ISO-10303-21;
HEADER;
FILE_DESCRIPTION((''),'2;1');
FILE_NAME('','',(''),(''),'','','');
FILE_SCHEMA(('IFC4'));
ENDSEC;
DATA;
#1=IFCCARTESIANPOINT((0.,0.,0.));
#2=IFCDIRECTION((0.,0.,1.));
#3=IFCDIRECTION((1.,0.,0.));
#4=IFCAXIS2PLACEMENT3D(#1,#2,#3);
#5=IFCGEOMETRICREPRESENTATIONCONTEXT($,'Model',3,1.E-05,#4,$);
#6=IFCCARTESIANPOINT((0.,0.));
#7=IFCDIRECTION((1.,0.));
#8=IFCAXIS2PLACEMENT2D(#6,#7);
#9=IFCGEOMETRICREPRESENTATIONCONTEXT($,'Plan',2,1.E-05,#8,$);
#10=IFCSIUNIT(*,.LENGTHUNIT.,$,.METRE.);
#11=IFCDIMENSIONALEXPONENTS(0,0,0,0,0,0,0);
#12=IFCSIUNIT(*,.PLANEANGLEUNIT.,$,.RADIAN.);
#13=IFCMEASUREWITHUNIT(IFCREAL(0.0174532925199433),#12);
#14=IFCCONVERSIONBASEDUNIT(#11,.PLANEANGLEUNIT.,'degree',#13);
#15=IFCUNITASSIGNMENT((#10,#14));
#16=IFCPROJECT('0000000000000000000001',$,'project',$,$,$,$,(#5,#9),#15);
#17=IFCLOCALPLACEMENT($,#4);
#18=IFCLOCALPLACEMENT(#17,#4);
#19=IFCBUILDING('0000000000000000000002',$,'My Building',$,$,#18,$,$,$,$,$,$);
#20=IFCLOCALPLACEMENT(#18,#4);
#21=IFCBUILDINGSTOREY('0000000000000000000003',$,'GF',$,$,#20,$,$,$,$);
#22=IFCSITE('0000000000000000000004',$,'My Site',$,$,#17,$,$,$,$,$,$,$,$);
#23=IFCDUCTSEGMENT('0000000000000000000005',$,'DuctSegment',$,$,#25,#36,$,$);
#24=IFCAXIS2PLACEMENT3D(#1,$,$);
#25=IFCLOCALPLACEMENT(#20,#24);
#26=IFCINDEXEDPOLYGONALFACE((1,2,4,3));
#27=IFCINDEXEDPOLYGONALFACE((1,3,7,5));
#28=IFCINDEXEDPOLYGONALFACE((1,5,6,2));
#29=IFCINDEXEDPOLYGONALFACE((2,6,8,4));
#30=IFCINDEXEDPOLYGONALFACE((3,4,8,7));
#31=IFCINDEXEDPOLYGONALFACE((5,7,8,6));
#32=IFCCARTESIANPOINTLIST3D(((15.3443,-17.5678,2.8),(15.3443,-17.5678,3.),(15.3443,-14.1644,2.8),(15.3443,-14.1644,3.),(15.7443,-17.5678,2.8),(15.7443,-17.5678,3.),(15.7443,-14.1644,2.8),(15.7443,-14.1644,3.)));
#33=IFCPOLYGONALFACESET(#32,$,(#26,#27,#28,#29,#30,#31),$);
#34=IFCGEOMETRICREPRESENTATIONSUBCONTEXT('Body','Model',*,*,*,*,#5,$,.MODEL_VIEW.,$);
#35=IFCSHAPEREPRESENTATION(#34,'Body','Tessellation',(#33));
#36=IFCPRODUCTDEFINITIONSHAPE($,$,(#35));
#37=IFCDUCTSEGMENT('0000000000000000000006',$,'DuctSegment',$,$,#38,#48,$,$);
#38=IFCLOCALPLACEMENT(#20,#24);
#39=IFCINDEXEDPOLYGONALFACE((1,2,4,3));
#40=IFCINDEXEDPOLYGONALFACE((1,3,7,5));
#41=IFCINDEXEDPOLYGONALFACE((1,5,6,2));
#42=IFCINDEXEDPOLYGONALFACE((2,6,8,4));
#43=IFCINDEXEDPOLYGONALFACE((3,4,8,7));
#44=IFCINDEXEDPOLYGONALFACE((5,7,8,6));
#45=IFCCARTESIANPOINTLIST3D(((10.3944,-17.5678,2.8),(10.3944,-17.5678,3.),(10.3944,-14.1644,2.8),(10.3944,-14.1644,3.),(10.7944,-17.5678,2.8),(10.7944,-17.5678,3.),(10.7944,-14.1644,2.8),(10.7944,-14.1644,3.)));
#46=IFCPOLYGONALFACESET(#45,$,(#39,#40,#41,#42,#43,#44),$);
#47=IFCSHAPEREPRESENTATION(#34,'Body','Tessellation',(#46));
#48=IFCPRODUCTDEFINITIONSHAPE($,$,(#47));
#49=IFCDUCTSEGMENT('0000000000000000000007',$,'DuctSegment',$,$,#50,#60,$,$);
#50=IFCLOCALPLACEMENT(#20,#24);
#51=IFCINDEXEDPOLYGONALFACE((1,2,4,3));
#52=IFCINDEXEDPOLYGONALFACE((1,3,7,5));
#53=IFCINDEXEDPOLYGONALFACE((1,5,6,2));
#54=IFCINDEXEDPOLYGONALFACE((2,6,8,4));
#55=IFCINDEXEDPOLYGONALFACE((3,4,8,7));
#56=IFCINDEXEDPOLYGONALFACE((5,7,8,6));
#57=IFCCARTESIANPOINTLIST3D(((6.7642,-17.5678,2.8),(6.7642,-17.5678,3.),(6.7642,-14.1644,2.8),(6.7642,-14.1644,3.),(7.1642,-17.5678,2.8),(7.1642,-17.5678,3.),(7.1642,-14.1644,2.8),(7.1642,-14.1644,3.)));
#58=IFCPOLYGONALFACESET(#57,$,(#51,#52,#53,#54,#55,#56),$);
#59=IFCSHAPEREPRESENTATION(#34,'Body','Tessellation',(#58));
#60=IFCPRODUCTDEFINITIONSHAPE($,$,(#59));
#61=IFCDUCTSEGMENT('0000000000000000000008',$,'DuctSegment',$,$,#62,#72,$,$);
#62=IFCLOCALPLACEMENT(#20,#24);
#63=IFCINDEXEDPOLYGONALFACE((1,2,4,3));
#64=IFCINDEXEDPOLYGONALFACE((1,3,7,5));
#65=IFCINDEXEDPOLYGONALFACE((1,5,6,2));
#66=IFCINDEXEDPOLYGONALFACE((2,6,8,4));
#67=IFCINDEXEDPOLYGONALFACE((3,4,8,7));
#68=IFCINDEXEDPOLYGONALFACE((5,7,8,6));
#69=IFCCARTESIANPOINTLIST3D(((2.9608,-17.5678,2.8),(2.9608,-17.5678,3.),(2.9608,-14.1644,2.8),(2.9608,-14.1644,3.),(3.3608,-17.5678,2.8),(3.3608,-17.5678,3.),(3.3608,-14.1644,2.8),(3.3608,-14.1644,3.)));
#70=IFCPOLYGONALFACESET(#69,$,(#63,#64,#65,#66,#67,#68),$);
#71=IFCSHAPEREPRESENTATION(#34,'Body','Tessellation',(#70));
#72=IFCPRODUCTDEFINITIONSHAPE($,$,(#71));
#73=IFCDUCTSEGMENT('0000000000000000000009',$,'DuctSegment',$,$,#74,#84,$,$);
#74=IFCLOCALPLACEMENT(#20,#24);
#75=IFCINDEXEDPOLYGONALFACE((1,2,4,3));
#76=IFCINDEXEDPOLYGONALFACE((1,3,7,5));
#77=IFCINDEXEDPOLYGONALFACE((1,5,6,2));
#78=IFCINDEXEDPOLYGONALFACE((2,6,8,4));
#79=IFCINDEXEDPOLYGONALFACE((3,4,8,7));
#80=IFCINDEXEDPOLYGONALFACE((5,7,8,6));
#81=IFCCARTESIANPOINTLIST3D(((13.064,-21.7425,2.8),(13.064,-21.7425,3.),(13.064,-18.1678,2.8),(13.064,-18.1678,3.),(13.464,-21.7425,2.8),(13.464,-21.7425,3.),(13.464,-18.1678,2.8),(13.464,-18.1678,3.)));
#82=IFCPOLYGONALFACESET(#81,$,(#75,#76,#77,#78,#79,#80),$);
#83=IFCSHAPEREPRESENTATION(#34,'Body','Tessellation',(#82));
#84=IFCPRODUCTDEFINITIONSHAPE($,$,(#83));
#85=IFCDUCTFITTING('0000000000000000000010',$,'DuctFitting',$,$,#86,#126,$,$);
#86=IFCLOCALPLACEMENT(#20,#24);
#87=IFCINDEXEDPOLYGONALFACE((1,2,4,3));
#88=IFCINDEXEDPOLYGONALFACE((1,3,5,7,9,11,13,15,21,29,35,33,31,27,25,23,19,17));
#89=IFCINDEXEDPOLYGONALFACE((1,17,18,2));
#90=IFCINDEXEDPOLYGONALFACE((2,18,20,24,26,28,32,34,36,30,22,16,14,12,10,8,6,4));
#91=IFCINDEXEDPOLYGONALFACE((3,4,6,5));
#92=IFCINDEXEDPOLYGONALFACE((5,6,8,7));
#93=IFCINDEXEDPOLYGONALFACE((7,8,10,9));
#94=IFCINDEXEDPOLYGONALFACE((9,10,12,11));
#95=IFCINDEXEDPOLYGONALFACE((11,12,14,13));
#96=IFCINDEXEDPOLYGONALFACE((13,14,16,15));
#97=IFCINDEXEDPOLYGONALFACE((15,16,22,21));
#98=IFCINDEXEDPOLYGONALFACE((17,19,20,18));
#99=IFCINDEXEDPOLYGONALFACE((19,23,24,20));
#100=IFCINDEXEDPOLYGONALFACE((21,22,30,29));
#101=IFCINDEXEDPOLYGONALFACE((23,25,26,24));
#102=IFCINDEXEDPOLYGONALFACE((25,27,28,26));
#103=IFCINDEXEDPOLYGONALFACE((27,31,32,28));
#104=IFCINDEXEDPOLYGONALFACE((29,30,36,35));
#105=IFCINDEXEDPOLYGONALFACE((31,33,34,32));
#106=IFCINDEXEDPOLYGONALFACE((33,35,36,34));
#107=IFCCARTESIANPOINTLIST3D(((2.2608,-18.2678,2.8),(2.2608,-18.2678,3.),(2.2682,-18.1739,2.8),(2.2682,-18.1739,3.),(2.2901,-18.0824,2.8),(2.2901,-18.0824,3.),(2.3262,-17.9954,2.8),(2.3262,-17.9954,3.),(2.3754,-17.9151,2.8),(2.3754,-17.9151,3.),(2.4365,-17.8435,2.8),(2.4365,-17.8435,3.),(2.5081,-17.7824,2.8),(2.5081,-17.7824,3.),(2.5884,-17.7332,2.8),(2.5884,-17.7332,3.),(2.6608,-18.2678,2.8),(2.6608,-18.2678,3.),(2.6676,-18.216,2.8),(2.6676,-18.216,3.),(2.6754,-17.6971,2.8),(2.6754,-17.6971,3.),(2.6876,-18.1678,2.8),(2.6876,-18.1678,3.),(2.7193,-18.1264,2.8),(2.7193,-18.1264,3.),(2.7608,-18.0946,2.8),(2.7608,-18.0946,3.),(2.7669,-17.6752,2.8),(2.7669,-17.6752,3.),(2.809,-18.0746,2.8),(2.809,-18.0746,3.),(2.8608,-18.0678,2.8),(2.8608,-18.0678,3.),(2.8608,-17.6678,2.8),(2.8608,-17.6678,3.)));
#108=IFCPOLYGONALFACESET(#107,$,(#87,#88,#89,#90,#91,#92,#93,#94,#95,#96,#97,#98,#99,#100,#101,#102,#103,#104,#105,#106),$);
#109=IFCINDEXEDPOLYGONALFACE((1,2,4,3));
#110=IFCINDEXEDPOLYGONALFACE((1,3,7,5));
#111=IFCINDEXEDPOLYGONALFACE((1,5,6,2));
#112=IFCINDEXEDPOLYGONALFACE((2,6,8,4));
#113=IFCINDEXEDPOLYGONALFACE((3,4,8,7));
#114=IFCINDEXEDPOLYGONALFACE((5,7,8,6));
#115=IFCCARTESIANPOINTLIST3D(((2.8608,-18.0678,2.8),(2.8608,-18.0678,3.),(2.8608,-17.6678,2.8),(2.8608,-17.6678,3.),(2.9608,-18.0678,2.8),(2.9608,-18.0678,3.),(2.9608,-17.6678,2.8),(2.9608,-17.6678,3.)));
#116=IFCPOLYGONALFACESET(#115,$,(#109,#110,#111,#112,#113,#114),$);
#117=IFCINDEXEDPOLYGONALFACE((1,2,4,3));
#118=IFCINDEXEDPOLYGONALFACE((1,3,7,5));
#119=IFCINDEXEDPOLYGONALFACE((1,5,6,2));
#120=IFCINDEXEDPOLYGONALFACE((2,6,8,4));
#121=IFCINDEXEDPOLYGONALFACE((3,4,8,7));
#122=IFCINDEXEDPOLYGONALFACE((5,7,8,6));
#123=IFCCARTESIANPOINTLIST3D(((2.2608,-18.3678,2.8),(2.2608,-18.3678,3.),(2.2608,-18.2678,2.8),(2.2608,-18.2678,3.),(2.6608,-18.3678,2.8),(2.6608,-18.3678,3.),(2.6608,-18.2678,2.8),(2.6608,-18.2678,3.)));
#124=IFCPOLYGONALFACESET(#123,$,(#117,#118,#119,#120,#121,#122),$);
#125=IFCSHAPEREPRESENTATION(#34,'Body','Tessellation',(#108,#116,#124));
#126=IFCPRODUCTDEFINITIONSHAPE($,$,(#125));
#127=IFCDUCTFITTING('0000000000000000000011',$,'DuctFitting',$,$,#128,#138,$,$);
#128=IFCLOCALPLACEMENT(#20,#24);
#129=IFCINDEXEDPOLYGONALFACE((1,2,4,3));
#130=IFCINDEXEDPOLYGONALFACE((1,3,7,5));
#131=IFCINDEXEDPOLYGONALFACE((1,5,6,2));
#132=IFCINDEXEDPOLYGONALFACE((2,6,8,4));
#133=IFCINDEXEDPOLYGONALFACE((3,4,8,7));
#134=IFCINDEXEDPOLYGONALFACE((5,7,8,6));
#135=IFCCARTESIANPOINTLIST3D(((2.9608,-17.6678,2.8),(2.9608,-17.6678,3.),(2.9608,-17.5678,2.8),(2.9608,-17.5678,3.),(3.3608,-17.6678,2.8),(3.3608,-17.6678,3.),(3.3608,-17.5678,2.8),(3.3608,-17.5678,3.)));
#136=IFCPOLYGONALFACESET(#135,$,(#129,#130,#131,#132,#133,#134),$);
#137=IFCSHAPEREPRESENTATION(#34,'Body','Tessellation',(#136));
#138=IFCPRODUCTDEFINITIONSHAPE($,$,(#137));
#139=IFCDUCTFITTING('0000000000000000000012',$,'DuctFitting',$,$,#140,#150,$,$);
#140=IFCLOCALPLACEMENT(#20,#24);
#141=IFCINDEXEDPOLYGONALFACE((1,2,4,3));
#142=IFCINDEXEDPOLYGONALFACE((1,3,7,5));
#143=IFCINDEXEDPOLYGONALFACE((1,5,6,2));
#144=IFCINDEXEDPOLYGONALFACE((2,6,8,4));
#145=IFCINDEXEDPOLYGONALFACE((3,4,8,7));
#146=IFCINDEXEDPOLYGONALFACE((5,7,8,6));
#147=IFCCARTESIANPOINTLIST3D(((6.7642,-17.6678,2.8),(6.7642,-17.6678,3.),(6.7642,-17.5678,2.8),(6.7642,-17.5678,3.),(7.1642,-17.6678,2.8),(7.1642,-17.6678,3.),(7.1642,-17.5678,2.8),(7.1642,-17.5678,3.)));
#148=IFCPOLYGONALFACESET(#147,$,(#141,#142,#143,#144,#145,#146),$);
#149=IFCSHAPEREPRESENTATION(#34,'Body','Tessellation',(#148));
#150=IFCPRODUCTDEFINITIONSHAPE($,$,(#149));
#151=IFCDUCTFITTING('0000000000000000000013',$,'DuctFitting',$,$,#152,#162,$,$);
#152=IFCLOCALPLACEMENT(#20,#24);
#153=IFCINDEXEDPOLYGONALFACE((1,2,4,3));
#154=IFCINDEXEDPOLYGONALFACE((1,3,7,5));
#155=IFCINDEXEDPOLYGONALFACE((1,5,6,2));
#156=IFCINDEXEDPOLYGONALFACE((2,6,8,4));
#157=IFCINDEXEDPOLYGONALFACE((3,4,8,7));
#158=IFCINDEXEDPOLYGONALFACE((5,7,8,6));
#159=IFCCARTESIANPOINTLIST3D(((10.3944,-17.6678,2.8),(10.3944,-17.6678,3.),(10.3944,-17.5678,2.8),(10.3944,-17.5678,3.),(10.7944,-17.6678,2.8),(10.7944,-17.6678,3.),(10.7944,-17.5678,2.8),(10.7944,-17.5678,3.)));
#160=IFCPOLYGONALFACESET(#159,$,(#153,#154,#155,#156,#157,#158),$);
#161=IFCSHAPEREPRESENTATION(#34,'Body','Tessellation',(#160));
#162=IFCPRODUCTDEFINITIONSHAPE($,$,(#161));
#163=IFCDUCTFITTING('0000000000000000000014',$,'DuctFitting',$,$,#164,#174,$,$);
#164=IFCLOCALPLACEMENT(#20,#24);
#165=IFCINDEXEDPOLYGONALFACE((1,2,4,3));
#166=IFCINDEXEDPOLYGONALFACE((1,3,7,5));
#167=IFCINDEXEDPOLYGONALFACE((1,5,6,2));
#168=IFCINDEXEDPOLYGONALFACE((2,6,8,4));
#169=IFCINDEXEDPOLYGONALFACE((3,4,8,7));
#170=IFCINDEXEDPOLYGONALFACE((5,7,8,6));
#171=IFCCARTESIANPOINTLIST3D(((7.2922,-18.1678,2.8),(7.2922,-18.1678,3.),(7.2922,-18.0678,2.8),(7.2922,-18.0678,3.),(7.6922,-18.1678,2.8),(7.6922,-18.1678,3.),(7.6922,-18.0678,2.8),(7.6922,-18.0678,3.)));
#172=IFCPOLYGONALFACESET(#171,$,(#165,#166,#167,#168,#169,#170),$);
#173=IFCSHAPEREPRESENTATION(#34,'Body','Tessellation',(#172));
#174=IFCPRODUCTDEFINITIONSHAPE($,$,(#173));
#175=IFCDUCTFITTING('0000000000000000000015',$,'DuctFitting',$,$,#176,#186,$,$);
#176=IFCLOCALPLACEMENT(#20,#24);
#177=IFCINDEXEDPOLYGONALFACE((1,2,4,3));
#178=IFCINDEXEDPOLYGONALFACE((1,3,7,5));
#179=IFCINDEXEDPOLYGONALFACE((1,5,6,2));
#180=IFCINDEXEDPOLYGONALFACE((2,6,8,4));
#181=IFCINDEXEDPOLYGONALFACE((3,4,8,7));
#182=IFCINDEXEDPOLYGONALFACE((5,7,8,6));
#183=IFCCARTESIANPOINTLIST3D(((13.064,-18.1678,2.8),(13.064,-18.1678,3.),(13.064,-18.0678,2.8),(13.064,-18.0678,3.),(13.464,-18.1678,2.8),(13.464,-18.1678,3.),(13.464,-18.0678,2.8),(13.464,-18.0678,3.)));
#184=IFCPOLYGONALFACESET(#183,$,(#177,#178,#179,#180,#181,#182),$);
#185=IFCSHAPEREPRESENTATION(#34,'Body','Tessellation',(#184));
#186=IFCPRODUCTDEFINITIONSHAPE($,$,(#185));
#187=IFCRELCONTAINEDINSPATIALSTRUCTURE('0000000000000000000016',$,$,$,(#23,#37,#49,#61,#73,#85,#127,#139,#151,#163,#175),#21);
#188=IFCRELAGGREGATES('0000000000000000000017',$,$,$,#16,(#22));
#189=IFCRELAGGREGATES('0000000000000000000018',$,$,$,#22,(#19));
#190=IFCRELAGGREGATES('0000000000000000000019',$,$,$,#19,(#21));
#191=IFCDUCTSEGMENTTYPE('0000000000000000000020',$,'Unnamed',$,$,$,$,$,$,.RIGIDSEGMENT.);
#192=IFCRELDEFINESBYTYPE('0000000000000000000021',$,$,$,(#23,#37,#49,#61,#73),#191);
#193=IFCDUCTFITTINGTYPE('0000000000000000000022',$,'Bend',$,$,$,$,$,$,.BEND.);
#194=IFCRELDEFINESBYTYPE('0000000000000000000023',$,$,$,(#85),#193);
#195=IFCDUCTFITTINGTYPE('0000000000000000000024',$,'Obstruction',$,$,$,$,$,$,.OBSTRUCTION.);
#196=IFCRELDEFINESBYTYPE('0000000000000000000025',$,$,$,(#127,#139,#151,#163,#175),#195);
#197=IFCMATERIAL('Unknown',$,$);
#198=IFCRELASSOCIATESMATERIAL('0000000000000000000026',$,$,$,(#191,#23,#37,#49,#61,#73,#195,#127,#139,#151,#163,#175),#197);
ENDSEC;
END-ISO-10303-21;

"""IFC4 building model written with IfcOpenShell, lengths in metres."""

from ifc_helpers import new_model, entity, si_unit, converted_unit, frame, origin_with_axes, origin_2d_with_axis, place, context, subcontext, project, spatial, line, arc, indexed_curve, rectangle, outline, extrude, source, transform, mapped, material, material_profile, profile_set, profile_usage, type_object, type_shapes, element, save


model = new_model("IFC4")

# Units and contexts
model_context = context("Model", 3, precision=1e-05, world=origin_with_axes())
plan_context = context("Plan", 2, precision=1e-05, world=origin_2d_with_axis())
body_context_1 = subcontext(model_context, "Body", "Model", "MODEL_VIEW")
ifc_project = project(units=[si_unit("LENGTHUNIT", "METRE"), converted_unit("PLANEANGLEUNIT", "degree", entity("IfcReal", 0.0174532925199433), si_unit("PLANEANGLEUNIT", "RADIAN"), dimensions=[0, 0, 0, 0, 0, 0, 0])], contexts=[model_context, plan_context])

# Site, building, storey
site_placement = place(None, origin_with_axes())
site = spatial("IfcSite", under=ifc_project, at=site_placement, Name="My Site")
building_placement = place(site_placement, origin_with_axes())
building = spatial("IfcBuilding", under=site, at=building_placement, Name="My Building")
storey_placement = place(building_placement, origin_with_axes())
storey = spatial("IfcBuildingStorey", under=building, at=storey_placement, Name="GF")

# Shared definitions
ifc_material = material(Name="Unknown")

# Duct segments
ifc_material_profile_1 = material_profile(ifc_material, rectangle(XDim=0.4, YDim=0.2))
ifc_profile_set_1 = profile_set([ifc_material_profile_1])
ifc_profile_usage_1 = profile_usage(ifc_profile_set_1, cardinal=5)
duct_segment_type = type_object("IfcDuctSegmentType", Name="Unnamed", PredefinedType="RIGIDSEGMENT", material=ifc_profile_set_1)
duct_segment_1_placement = place(storey_placement, frame((15.5443, -17.5678, 2.9), z_axis=(0.0, 1.0, 0.0), x_axis=(-1.0, 0.0, 0.0)))
element("IfcDuctSegment", 1, at=duct_segment_1_placement, inside=storey, type_object=duct_segment_type, material=ifc_profile_usage_1, Name="DuctSegment", context=body_context_1, shape_type="SweptSolid", body=[
    extrude(rectangle(XDim=0.4, YDim=0.2), origin_with_axes(), (0.0, 0.0, 1.0), 3.4033),
])
ifc_profile_usage_2 = profile_usage(ifc_profile_set_1, cardinal=5)
duct_segment_2_placement = place(storey_placement, frame((10.5944, -17.5678, 2.9), z_axis=(0.0, 1.0, 0.0), x_axis=(-1.0, 0.0, 0.0)))
element("IfcDuctSegment", 2, at=duct_segment_2_placement, inside=storey, type_object=duct_segment_type, material=ifc_profile_usage_2, Name="DuctSegment", context=body_context_1, shape_type="SweptSolid", body=[
    extrude(rectangle(XDim=0.4, YDim=0.2), origin_with_axes(), (0.0, 0.0, 1.0), 3.4033),
])
ifc_profile_usage_3 = profile_usage(ifc_profile_set_1, cardinal=5)
duct_segment_3_placement = place(storey_placement, frame((6.9642, -17.5678, 2.9), z_axis=(0.0, 1.0, 0.0), x_axis=(-1.0, 0.0, 0.0)))
element("IfcDuctSegment", 3, at=duct_segment_3_placement, inside=storey, type_object=duct_segment_type, material=ifc_profile_usage_3, Name="DuctSegment", context=body_context_1, shape_type="SweptSolid", body=[
    extrude(rectangle(XDim=0.4, YDim=0.2), origin_with_axes(), (0.0, 0.0, 1.0), 3.4033),
])
ifc_profile_usage_4 = profile_usage(ifc_profile_set_1, cardinal=5)
duct_segment_4_placement = place(storey_placement, frame((3.1608, -17.5678, 2.9), z_axis=(0.0, 1.0, 0.0), x_axis=(-1.0, 0.0, 0.0)))
element("IfcDuctSegment", 4, at=duct_segment_4_placement, inside=storey, type_object=duct_segment_type, material=ifc_profile_usage_4, Name="DuctSegment", context=body_context_1, shape_type="SweptSolid", body=[
    extrude(rectangle(XDim=0.4, YDim=0.2), origin_with_axes(), (0.0, 0.0, 1.0), 3.4033),
])
ifc_profile_usage_5 = profile_usage(ifc_profile_set_1, cardinal=5)
duct_segment_5_placement = place(storey_placement, frame((13.264, -18.1678, 2.9), z_axis=(0.0, -1.0, 0.0), x_axis=(1.0, 0.0, 0.0)))
element("IfcDuctSegment", 5, at=duct_segment_5_placement, inside=storey, type_object=duct_segment_type, material=ifc_profile_usage_5, Name="DuctSegment", context=body_context_1, shape_type="SweptSolid", body=[
    extrude(rectangle(XDim=0.4, YDim=0.2), origin_with_axes(), (0.0, 0.0, 1.0), 3.5747),
])

# Duct fittings
duct_fitting_type_1 = type_object("IfcDuctFittingType", Name="Bend", PredefinedType="BEND")
shared_shape_1 = source(origin_with_axes(), body_context_1, "Body", "SweptSolid", [
    extrude(outline(indexed_curve([(0.2, 0.0), (0.2586, 0.1414), (0.4, 0.2), (0.4, 0.6), (-0.0243, 0.4243), (-0.2, 0.0)], segments=[arc(1, 2, 3), line(3, 4), arc(4, 5, 6), line(6, 1)])), frame((0.0, -0.1, 0.1), z_axis=(0.0, -1.0, 0.0), x_axis=(1.0, 0.0, 0.0)), (0.0, 0.0, -1.0), 0.2),
    extrude(rectangle(XDim=0.4, YDim=0.2), origin_with_axes(), (0.0, 0.0, 1.0), 0.1),
    extrude(rectangle(XDim=0.4, YDim=0.2), frame((0.4, 0.0, 0.5), z_axis=(1.0, 0.0, 0.0), x_axis=(0.0, 0.0, 1.0)), (0.0, 0.0, 1.0), 0.1),
])
type_shapes(duct_fitting_type_1, [shared_shape_1])
duct_fitting_1_placement = place(storey_placement, frame((2.9608, -17.8678, 2.9), z_axis=(-1.0, 0.0, 0.0), x_axis=(0.0, -1.0, 0.0)))
element("IfcDuctFitting", 6, at=duct_fitting_1_placement, inside=storey, type_object=duct_fitting_type_1, Name="DuctFitting", context=body_context_1, shape_type="MappedRepresentation", body=[
    mapped(shared_shape_1, transform((0.0, 0.0, 0.0), x_axis=(1.0, 0.0, 0.0), y_axis=(0.0, 1.0, 0.0), z_axis=(0.0, 0.0, 1.0), scale=1.0)),
])
ifc_material_profile_2 = material_profile(ifc_material, rectangle(XDim=0.4, YDim=0.2))
ifc_profile_set_2 = profile_set([ifc_material_profile_2])
ifc_profile_usage_6 = profile_usage(ifc_profile_set_2, cardinal=5)
duct_fitting_type_2 = type_object("IfcDuctFittingType", Name="Obstruction", PredefinedType="OBSTRUCTION", material=ifc_profile_set_2)
duct_fitting_2_placement = place(storey_placement, frame((3.1608, -17.6678, 2.9), z_axis=(0.0, 1.0, 0.0), x_axis=(-1.0, 0.0, 0.0)))
element("IfcDuctFitting", 7, at=duct_fitting_2_placement, inside=storey, type_object=duct_fitting_type_2, material=ifc_profile_usage_6, Name="DuctFitting", context=body_context_1, shape_type="SweptSolid", body=[
    extrude(rectangle(XDim=0.4, YDim=0.2), origin_with_axes(), (0.0, 0.0, 1.0), 0.1),
])
ifc_profile_usage_7 = profile_usage(ifc_profile_set_2, cardinal=5)
duct_fitting_3_placement = place(storey_placement, frame((6.9642, -17.6678, 2.9), z_axis=(0.0, 1.0, 0.0), x_axis=(-1.0, 0.0, 0.0)))
element("IfcDuctFitting", 8, at=duct_fitting_3_placement, inside=storey, type_object=duct_fitting_type_2, material=ifc_profile_usage_7, Name="DuctFitting", context=body_context_1, shape_type="SweptSolid", body=[
    extrude(rectangle(XDim=0.4, YDim=0.2), origin_with_axes(), (0.0, 0.0, 1.0), 0.1),
])
ifc_profile_usage_8 = profile_usage(ifc_profile_set_2, cardinal=5)
duct_fitting_4_placement = place(storey_placement, frame((10.5944, -17.6678, 2.9), z_axis=(0.0, 1.0, 0.0), x_axis=(-1.0, 0.0, 0.0)))
element("IfcDuctFitting", 9, at=duct_fitting_4_placement, inside=storey, type_object=duct_fitting_type_2, material=ifc_profile_usage_8, Name="DuctFitting", context=body_context_1, shape_type="SweptSolid", body=[
    extrude(rectangle(XDim=0.4, YDim=0.2), origin_with_axes(), (0.0, 0.0, 1.0), 0.1),
])
ifc_profile_usage_9 = profile_usage(ifc_profile_set_2, cardinal=5)
duct_fitting_5_placement = place(storey_placement, frame((7.4922, -18.0678, 2.9), z_axis=(0.0, -1.0, 0.0), x_axis=(1.0, 0.0, 0.0)))
element("IfcDuctFitting", 10, at=duct_fitting_5_placement, inside=storey, type_object=duct_fitting_type_2, material=ifc_profile_usage_9, Name="DuctFitting", context=body_context_1, shape_type="SweptSolid", body=[
    extrude(rectangle(XDim=0.4, YDim=0.2), origin_with_axes(), (0.0, 0.0, 1.0), 0.1),
])
ifc_profile_usage_10 = profile_usage(ifc_profile_set_2, cardinal=5)
duct_fitting_6_placement = place(storey_placement, frame((13.264, -18.0678, 2.9), z_axis=(0.0, -1.0, 0.0), x_axis=(1.0, 0.0, 0.0)))
element("IfcDuctFitting", 11, at=duct_fitting_6_placement, inside=storey, type_object=duct_fitting_type_2, material=ifc_profile_usage_10, Name="DuctFitting", context=body_context_1, shape_type="SweptSolid", body=[
    extrude(rectangle(XDim=0.4, YDim=0.2), origin_with_axes(), (0.0, 0.0, 1.0), 0.1),
])

save(model, "model.ifc")
